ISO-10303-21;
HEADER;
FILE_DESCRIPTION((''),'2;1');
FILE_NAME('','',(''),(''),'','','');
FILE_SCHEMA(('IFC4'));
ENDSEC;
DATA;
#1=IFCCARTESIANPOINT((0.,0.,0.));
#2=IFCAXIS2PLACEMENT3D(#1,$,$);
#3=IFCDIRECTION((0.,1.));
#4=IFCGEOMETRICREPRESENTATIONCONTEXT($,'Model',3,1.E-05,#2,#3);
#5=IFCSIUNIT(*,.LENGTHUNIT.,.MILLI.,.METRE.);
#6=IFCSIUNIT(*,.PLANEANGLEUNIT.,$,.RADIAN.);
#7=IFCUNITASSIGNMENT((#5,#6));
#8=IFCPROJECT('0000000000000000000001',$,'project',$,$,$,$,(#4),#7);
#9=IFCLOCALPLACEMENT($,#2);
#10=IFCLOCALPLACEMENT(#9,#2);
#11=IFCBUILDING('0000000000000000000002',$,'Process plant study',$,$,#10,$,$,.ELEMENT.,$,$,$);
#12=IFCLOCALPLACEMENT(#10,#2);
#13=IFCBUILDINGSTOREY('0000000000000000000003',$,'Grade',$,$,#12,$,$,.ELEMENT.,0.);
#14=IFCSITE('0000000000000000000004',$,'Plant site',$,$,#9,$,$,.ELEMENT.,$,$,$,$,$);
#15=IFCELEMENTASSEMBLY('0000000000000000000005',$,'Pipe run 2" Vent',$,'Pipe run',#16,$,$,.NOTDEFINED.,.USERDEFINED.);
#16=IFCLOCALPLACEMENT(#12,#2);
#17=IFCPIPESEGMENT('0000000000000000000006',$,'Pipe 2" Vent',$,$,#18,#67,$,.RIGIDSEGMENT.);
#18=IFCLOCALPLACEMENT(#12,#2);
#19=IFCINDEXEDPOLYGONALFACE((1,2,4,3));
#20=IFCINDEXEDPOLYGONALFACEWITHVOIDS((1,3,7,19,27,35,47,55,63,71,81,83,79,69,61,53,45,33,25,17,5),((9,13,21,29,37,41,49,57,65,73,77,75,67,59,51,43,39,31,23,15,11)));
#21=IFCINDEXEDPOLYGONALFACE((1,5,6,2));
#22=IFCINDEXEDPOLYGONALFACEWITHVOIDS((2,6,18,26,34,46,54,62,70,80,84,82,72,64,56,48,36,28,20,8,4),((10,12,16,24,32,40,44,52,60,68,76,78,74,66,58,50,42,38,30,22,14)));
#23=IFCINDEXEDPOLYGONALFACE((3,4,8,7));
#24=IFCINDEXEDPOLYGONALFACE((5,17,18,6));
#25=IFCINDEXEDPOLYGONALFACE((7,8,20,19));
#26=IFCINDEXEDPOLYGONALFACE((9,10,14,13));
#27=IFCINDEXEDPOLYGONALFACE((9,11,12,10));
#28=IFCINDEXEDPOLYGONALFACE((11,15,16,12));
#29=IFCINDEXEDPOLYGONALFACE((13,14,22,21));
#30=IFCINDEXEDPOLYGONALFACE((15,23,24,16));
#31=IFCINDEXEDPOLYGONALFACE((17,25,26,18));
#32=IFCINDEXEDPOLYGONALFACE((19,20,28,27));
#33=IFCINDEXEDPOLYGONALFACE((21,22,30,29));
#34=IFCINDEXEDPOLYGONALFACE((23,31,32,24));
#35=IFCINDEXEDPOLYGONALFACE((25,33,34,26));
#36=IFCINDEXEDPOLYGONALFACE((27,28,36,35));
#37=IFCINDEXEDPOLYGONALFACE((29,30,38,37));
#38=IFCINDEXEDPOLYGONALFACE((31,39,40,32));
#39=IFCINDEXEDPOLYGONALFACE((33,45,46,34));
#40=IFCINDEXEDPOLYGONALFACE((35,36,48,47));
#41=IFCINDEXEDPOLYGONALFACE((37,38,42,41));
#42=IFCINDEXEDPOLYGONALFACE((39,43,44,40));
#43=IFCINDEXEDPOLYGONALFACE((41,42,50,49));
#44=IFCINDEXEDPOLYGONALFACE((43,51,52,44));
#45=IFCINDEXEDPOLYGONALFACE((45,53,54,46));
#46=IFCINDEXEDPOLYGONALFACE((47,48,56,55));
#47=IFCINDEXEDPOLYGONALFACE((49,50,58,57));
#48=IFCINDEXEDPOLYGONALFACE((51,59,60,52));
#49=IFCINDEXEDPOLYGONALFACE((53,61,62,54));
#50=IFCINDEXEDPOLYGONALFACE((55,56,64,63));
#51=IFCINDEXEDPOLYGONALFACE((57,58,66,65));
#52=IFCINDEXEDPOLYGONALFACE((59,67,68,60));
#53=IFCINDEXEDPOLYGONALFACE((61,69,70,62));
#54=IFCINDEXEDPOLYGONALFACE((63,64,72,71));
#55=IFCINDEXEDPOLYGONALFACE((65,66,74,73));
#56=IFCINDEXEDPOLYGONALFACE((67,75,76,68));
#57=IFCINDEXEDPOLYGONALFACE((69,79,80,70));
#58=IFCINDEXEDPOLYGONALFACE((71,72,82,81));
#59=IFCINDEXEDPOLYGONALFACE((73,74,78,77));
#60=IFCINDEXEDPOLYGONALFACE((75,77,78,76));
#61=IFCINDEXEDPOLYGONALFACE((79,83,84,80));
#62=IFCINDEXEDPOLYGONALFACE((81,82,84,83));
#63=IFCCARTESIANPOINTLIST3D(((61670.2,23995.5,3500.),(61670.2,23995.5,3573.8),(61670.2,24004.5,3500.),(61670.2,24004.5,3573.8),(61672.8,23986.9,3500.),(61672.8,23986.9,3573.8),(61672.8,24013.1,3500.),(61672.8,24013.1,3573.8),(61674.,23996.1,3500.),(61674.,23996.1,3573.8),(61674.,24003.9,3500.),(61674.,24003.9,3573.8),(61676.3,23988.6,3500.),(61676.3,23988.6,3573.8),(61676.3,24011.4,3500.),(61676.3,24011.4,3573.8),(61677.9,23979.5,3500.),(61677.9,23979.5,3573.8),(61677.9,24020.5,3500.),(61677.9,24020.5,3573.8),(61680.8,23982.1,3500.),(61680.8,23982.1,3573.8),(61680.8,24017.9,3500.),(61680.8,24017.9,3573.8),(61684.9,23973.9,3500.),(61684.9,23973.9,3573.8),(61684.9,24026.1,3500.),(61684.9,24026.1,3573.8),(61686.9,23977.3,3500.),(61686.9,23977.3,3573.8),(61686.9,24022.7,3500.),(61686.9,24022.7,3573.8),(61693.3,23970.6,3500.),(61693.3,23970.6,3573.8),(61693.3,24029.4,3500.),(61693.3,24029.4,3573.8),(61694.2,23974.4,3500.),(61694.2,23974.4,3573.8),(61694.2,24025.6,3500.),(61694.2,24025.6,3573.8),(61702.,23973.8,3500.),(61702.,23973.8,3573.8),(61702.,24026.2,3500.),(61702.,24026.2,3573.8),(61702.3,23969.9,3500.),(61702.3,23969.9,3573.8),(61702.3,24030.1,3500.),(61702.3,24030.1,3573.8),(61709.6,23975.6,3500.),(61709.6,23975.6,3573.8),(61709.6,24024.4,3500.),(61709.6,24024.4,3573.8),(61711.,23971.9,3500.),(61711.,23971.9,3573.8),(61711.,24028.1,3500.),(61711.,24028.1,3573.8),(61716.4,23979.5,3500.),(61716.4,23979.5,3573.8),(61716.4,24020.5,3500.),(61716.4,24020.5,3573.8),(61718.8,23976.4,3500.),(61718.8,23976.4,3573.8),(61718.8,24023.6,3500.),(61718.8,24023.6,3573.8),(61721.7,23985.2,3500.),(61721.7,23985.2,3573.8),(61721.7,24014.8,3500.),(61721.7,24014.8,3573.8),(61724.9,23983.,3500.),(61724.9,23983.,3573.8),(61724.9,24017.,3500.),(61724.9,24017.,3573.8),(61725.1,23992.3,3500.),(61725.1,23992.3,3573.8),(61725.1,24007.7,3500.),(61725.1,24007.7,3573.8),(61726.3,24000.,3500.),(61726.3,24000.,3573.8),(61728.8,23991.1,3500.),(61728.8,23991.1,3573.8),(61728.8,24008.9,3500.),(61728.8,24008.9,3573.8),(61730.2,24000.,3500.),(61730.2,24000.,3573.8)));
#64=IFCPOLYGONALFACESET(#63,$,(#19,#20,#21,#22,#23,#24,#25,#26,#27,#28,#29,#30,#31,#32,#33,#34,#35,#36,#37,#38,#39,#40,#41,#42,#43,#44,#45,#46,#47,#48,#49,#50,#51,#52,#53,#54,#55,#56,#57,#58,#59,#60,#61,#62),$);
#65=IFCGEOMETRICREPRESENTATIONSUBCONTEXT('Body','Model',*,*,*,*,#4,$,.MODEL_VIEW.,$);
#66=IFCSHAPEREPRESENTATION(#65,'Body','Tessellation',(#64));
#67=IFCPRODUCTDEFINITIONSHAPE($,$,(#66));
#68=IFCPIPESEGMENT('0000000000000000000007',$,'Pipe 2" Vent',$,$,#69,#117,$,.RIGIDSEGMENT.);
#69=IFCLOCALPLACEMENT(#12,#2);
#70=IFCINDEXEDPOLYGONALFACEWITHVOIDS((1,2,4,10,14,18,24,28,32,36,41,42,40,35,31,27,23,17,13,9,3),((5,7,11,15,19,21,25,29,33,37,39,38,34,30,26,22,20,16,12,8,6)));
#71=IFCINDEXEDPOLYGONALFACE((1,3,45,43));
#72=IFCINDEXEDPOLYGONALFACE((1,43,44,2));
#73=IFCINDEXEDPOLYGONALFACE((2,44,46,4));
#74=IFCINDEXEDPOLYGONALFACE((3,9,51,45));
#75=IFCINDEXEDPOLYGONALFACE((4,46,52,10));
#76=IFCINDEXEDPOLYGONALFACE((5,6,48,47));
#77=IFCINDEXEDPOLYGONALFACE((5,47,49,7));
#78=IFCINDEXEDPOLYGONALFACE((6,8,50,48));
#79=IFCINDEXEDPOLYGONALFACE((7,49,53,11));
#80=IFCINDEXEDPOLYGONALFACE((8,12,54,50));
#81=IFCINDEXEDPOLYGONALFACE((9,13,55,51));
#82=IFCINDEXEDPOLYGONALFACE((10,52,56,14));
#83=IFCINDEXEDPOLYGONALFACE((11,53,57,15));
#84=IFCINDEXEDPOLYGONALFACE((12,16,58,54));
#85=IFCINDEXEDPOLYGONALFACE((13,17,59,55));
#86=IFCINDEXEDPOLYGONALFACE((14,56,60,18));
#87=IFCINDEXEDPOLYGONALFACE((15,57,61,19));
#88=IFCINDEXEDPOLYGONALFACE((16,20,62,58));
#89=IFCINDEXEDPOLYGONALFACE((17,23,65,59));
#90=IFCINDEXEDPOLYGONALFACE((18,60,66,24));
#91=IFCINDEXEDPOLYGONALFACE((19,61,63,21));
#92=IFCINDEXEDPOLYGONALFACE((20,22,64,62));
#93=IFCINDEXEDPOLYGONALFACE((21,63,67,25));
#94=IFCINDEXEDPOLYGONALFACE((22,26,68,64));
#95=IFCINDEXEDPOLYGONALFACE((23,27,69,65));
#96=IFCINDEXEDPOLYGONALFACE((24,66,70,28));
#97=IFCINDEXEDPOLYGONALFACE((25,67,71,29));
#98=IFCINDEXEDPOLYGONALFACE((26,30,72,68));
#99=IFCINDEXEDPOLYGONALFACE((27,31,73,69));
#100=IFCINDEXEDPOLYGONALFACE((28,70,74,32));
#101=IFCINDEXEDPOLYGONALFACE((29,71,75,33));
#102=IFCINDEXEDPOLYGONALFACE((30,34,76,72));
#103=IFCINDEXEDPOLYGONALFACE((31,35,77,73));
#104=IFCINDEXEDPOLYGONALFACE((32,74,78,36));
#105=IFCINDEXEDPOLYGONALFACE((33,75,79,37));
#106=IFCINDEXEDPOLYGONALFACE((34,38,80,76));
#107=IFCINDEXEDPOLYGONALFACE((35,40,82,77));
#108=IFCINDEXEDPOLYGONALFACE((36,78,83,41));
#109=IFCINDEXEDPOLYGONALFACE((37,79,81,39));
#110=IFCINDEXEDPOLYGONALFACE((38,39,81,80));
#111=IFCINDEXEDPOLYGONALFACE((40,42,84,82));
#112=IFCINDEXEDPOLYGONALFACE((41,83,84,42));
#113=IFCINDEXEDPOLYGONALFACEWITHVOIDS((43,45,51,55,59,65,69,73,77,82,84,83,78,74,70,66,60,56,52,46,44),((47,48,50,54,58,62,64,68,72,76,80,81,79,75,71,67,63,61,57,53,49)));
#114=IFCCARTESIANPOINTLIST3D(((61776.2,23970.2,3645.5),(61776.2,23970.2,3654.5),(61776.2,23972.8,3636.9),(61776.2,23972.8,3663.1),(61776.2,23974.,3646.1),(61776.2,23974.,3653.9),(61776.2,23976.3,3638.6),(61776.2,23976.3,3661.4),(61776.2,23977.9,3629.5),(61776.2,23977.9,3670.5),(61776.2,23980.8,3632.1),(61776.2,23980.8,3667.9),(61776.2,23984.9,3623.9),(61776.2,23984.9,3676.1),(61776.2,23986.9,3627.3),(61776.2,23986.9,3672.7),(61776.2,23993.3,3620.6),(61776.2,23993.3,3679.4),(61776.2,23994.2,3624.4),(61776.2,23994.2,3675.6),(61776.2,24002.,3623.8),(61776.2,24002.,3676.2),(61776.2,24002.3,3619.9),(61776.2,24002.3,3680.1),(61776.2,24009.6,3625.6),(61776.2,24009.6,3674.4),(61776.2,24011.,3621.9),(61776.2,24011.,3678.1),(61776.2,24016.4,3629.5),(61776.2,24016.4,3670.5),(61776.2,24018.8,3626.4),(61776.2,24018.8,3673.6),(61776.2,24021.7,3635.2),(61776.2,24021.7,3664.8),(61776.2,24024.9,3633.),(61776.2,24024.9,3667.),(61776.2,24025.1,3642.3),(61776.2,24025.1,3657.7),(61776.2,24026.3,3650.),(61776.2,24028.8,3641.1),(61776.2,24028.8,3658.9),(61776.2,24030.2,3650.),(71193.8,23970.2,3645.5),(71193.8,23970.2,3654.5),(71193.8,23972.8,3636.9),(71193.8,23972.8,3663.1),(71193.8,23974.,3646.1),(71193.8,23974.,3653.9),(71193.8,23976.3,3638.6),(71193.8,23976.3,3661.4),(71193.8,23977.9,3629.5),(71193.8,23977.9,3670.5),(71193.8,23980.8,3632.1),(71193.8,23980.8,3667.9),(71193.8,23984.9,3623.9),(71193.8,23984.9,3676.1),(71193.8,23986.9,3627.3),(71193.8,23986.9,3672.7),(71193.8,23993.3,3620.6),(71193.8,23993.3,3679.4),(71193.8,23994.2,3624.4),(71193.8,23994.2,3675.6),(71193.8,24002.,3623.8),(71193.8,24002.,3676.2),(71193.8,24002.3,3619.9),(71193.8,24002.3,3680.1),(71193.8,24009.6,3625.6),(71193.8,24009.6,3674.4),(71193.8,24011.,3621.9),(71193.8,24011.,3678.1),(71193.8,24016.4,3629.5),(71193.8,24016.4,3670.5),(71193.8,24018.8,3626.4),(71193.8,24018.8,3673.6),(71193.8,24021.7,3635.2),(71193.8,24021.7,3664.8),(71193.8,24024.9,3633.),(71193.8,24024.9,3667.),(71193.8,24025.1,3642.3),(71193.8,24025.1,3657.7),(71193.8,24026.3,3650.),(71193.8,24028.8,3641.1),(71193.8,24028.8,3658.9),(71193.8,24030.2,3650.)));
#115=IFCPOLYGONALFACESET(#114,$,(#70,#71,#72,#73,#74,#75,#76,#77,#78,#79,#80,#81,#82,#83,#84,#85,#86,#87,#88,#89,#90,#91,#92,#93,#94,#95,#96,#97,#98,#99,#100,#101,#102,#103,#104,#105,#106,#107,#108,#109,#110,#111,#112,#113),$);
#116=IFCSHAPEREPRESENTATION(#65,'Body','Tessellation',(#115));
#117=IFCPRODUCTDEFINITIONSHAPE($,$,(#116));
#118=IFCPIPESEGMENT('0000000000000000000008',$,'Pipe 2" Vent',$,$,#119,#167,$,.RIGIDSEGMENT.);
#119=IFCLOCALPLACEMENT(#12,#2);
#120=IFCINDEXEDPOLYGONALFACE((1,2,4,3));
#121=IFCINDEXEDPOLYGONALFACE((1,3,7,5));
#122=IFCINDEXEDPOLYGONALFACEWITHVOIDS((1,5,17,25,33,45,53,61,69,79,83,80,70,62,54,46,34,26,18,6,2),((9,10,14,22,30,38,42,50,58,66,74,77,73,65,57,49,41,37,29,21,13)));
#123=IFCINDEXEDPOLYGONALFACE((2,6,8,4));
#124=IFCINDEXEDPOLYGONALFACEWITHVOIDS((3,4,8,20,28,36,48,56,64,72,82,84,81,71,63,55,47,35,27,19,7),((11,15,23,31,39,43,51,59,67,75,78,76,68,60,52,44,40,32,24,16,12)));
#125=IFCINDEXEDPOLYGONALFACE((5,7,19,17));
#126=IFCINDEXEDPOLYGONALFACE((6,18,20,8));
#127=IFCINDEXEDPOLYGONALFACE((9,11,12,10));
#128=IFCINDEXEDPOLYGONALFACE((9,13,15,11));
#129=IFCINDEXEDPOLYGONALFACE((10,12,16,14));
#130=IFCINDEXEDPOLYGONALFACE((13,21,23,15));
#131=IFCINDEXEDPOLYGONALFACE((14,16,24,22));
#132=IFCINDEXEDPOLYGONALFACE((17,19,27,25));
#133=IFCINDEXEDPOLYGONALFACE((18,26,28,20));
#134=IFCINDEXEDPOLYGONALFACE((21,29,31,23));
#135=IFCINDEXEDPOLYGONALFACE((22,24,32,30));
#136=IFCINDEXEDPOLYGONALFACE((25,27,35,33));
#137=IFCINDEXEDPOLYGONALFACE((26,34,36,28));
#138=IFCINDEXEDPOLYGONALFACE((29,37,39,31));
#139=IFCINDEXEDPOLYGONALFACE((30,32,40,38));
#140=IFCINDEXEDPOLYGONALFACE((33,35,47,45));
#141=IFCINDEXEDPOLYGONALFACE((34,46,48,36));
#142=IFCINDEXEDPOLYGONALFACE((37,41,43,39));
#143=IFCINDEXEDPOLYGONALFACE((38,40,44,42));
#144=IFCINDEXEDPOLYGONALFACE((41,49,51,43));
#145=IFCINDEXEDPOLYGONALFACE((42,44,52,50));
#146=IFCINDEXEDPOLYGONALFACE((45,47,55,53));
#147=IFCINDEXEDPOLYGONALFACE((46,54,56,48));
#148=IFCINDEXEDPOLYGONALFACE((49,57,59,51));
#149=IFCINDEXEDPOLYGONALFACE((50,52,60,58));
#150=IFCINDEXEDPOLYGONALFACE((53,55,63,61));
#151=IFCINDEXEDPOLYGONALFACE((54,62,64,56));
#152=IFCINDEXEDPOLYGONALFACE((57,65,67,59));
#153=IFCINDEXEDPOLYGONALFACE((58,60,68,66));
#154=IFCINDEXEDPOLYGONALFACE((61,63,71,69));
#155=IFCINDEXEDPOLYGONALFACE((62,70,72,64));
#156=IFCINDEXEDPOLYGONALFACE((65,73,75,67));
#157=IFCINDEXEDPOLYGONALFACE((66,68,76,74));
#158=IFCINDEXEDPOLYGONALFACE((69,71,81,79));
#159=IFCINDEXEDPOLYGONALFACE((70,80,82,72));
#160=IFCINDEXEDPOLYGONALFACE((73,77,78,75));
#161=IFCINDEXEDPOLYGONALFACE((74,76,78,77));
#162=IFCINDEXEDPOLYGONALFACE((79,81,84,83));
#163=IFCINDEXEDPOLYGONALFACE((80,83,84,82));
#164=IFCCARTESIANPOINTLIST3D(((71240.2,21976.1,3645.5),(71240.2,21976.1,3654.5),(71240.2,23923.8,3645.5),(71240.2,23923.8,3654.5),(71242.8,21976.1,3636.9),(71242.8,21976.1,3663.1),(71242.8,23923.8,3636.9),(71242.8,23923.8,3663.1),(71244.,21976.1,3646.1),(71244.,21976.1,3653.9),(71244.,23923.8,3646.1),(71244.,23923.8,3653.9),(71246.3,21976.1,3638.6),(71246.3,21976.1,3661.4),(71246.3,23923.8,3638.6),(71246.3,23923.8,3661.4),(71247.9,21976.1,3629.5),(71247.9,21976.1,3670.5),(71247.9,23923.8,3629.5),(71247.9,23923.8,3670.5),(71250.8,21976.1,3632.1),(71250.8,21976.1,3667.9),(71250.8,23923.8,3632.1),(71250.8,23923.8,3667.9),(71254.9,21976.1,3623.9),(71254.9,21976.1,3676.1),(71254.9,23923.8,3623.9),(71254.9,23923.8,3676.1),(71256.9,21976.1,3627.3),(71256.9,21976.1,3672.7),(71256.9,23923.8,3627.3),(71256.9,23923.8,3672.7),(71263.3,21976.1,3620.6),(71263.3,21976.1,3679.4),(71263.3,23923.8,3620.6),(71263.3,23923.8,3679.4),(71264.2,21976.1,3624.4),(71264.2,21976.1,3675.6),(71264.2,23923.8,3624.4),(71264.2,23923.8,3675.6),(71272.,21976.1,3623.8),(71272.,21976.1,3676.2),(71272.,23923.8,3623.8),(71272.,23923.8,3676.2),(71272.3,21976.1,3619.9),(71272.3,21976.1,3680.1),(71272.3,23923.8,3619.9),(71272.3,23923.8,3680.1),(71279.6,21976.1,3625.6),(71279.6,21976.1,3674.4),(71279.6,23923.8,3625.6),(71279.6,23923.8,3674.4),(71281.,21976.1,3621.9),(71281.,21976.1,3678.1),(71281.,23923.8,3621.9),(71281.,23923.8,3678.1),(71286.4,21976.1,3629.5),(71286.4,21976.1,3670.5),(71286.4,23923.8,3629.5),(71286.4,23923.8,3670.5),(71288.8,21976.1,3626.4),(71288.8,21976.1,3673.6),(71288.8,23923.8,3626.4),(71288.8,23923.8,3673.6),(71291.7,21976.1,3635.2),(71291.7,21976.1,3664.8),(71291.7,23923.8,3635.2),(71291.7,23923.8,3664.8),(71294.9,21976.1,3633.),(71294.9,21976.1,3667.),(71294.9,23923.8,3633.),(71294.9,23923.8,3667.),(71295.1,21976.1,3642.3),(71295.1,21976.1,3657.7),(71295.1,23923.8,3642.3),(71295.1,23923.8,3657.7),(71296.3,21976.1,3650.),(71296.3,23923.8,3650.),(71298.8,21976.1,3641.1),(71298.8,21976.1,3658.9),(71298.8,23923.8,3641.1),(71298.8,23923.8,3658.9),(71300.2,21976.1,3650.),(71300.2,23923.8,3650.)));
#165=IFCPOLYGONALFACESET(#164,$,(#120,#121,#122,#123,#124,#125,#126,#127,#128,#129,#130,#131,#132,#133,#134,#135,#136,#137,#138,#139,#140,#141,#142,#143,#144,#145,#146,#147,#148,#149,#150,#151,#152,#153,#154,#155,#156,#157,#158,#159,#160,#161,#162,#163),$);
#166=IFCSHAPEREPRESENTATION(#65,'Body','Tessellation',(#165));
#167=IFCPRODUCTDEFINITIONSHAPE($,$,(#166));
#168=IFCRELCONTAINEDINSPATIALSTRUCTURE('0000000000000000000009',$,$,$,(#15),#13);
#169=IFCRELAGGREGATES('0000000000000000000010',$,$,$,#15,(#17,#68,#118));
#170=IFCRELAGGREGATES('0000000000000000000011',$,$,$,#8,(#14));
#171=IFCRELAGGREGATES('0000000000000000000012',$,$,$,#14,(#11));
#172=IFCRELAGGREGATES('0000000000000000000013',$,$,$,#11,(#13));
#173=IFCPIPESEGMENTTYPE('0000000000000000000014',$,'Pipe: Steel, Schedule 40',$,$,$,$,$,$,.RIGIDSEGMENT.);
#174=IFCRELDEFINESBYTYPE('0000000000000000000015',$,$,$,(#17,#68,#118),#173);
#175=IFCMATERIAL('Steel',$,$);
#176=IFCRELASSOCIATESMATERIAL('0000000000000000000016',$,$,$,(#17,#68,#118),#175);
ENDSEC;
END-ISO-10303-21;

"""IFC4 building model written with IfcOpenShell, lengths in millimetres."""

from ifc_helpers import new_model, si_unit, direction, frame, origin, origin_with_axes, origin_2d, place, context, subcontext, project, spatial, hollow_circle, extrude, material, type_object, element, aggregate, save


model = new_model("IFC4")

# Units and contexts
model_context = context("Model", 3, precision=1e-05, world=origin(), true_north=direction((0.0, 1.0)))
body_context = subcontext(model_context, "Body", "Model", "MODEL_VIEW")
ifc_project = project(units=[si_unit("LENGTHUNIT", "METRE", prefix="MILLI"), si_unit("PLANEANGLEUNIT", "RADIAN")], contexts=[model_context])

# Site, building, storey
site_placement = place(None, origin())
site = spatial("IfcSite", under=ifc_project, at=site_placement, Name="Plant site", CompositionType="ELEMENT")
building_placement = place(site_placement, origin())
building = spatial("IfcBuilding", under=site, at=building_placement, Name="Process plant study", CompositionType="ELEMENT")
storey_placement = place(building_placement, origin())
storey = spatial("IfcBuildingStorey", under=building, at=storey_placement, Name="Grade", CompositionType="ELEMENT", Elevation=0.0)

# Element assembly, pipe segments
assembly_1_placement = place(storey_placement, origin_with_axes())
assembly_1 = element("IfcElementAssembly", 1, at=assembly_1_placement, inside=storey, Name="Pipe run 2\" Vent", ObjectType="Pipe run", AssemblyPlace="NOTDEFINED", PredefinedType="USERDEFINED")
ifc_material = material(Name="Steel")
pipe_segment_type = type_object("IfcPipeSegmentType", Name="Pipe: Steel, Schedule 40", PredefinedType="RIGIDSEGMENT")
pipe_segment_1_placement = place(storey_placement, origin_with_axes())
pipe_segment_1 = element("IfcPipeSegment", 2, at=pipe_segment_1_placement, type_object=pipe_segment_type, material=ifc_material, Name="Pipe 2\" Vent", PredefinedType="RIGIDSEGMENT", context=body_context, shape_type="SweptSolid", body=[
    extrude(hollow_circle(Radius=30.2, WallThickness=3.9, at=origin_2d()), frame((61700.0, 24000.0, 3500.0), z_axis=(0.0, 0.0, 1.0), x_axis=(1.0, 0.0, 0.0)), (0.0, 0.0, 1.0), 73.8),
])
pipe_segment_2_placement = place(storey_placement, origin_with_axes())
pipe_segment_2 = element("IfcPipeSegment", 3, at=pipe_segment_2_placement, type_object=pipe_segment_type, material=ifc_material, Name="Pipe 2\" Vent", PredefinedType="RIGIDSEGMENT", context=body_context, shape_type="SweptSolid", body=[
    extrude(hollow_circle(Radius=30.2, WallThickness=3.9, at=origin_2d()), frame((61776.2, 24000.0, 3650.0), z_axis=(1.0, 0.0, 0.0), x_axis=(0.0, 1.0, 0.0)), (0.0, 0.0, 1.0), 9417.6),
])
pipe_segment_3_placement = place(storey_placement, origin_with_axes())
pipe_segment_3 = element("IfcPipeSegment", 4, at=pipe_segment_3_placement, type_object=pipe_segment_type, material=ifc_material, Name="Pipe 2\" Vent", PredefinedType="RIGIDSEGMENT", context=body_context, shape_type="SweptSolid", body=[
    extrude(hollow_circle(Radius=30.2, WallThickness=3.9, at=origin_2d()), frame((71270.0, 23923.8, 3650.0), z_axis=(0.0, -1.0, 0.0), x_axis=(1.0, 0.0, 0.0)), (0.0, 0.0, 1.0), 1947.7),
])

aggregate(assembly_1, [pipe_segment_1, pipe_segment_2, pipe_segment_3])

save(model, "model.ifc")
